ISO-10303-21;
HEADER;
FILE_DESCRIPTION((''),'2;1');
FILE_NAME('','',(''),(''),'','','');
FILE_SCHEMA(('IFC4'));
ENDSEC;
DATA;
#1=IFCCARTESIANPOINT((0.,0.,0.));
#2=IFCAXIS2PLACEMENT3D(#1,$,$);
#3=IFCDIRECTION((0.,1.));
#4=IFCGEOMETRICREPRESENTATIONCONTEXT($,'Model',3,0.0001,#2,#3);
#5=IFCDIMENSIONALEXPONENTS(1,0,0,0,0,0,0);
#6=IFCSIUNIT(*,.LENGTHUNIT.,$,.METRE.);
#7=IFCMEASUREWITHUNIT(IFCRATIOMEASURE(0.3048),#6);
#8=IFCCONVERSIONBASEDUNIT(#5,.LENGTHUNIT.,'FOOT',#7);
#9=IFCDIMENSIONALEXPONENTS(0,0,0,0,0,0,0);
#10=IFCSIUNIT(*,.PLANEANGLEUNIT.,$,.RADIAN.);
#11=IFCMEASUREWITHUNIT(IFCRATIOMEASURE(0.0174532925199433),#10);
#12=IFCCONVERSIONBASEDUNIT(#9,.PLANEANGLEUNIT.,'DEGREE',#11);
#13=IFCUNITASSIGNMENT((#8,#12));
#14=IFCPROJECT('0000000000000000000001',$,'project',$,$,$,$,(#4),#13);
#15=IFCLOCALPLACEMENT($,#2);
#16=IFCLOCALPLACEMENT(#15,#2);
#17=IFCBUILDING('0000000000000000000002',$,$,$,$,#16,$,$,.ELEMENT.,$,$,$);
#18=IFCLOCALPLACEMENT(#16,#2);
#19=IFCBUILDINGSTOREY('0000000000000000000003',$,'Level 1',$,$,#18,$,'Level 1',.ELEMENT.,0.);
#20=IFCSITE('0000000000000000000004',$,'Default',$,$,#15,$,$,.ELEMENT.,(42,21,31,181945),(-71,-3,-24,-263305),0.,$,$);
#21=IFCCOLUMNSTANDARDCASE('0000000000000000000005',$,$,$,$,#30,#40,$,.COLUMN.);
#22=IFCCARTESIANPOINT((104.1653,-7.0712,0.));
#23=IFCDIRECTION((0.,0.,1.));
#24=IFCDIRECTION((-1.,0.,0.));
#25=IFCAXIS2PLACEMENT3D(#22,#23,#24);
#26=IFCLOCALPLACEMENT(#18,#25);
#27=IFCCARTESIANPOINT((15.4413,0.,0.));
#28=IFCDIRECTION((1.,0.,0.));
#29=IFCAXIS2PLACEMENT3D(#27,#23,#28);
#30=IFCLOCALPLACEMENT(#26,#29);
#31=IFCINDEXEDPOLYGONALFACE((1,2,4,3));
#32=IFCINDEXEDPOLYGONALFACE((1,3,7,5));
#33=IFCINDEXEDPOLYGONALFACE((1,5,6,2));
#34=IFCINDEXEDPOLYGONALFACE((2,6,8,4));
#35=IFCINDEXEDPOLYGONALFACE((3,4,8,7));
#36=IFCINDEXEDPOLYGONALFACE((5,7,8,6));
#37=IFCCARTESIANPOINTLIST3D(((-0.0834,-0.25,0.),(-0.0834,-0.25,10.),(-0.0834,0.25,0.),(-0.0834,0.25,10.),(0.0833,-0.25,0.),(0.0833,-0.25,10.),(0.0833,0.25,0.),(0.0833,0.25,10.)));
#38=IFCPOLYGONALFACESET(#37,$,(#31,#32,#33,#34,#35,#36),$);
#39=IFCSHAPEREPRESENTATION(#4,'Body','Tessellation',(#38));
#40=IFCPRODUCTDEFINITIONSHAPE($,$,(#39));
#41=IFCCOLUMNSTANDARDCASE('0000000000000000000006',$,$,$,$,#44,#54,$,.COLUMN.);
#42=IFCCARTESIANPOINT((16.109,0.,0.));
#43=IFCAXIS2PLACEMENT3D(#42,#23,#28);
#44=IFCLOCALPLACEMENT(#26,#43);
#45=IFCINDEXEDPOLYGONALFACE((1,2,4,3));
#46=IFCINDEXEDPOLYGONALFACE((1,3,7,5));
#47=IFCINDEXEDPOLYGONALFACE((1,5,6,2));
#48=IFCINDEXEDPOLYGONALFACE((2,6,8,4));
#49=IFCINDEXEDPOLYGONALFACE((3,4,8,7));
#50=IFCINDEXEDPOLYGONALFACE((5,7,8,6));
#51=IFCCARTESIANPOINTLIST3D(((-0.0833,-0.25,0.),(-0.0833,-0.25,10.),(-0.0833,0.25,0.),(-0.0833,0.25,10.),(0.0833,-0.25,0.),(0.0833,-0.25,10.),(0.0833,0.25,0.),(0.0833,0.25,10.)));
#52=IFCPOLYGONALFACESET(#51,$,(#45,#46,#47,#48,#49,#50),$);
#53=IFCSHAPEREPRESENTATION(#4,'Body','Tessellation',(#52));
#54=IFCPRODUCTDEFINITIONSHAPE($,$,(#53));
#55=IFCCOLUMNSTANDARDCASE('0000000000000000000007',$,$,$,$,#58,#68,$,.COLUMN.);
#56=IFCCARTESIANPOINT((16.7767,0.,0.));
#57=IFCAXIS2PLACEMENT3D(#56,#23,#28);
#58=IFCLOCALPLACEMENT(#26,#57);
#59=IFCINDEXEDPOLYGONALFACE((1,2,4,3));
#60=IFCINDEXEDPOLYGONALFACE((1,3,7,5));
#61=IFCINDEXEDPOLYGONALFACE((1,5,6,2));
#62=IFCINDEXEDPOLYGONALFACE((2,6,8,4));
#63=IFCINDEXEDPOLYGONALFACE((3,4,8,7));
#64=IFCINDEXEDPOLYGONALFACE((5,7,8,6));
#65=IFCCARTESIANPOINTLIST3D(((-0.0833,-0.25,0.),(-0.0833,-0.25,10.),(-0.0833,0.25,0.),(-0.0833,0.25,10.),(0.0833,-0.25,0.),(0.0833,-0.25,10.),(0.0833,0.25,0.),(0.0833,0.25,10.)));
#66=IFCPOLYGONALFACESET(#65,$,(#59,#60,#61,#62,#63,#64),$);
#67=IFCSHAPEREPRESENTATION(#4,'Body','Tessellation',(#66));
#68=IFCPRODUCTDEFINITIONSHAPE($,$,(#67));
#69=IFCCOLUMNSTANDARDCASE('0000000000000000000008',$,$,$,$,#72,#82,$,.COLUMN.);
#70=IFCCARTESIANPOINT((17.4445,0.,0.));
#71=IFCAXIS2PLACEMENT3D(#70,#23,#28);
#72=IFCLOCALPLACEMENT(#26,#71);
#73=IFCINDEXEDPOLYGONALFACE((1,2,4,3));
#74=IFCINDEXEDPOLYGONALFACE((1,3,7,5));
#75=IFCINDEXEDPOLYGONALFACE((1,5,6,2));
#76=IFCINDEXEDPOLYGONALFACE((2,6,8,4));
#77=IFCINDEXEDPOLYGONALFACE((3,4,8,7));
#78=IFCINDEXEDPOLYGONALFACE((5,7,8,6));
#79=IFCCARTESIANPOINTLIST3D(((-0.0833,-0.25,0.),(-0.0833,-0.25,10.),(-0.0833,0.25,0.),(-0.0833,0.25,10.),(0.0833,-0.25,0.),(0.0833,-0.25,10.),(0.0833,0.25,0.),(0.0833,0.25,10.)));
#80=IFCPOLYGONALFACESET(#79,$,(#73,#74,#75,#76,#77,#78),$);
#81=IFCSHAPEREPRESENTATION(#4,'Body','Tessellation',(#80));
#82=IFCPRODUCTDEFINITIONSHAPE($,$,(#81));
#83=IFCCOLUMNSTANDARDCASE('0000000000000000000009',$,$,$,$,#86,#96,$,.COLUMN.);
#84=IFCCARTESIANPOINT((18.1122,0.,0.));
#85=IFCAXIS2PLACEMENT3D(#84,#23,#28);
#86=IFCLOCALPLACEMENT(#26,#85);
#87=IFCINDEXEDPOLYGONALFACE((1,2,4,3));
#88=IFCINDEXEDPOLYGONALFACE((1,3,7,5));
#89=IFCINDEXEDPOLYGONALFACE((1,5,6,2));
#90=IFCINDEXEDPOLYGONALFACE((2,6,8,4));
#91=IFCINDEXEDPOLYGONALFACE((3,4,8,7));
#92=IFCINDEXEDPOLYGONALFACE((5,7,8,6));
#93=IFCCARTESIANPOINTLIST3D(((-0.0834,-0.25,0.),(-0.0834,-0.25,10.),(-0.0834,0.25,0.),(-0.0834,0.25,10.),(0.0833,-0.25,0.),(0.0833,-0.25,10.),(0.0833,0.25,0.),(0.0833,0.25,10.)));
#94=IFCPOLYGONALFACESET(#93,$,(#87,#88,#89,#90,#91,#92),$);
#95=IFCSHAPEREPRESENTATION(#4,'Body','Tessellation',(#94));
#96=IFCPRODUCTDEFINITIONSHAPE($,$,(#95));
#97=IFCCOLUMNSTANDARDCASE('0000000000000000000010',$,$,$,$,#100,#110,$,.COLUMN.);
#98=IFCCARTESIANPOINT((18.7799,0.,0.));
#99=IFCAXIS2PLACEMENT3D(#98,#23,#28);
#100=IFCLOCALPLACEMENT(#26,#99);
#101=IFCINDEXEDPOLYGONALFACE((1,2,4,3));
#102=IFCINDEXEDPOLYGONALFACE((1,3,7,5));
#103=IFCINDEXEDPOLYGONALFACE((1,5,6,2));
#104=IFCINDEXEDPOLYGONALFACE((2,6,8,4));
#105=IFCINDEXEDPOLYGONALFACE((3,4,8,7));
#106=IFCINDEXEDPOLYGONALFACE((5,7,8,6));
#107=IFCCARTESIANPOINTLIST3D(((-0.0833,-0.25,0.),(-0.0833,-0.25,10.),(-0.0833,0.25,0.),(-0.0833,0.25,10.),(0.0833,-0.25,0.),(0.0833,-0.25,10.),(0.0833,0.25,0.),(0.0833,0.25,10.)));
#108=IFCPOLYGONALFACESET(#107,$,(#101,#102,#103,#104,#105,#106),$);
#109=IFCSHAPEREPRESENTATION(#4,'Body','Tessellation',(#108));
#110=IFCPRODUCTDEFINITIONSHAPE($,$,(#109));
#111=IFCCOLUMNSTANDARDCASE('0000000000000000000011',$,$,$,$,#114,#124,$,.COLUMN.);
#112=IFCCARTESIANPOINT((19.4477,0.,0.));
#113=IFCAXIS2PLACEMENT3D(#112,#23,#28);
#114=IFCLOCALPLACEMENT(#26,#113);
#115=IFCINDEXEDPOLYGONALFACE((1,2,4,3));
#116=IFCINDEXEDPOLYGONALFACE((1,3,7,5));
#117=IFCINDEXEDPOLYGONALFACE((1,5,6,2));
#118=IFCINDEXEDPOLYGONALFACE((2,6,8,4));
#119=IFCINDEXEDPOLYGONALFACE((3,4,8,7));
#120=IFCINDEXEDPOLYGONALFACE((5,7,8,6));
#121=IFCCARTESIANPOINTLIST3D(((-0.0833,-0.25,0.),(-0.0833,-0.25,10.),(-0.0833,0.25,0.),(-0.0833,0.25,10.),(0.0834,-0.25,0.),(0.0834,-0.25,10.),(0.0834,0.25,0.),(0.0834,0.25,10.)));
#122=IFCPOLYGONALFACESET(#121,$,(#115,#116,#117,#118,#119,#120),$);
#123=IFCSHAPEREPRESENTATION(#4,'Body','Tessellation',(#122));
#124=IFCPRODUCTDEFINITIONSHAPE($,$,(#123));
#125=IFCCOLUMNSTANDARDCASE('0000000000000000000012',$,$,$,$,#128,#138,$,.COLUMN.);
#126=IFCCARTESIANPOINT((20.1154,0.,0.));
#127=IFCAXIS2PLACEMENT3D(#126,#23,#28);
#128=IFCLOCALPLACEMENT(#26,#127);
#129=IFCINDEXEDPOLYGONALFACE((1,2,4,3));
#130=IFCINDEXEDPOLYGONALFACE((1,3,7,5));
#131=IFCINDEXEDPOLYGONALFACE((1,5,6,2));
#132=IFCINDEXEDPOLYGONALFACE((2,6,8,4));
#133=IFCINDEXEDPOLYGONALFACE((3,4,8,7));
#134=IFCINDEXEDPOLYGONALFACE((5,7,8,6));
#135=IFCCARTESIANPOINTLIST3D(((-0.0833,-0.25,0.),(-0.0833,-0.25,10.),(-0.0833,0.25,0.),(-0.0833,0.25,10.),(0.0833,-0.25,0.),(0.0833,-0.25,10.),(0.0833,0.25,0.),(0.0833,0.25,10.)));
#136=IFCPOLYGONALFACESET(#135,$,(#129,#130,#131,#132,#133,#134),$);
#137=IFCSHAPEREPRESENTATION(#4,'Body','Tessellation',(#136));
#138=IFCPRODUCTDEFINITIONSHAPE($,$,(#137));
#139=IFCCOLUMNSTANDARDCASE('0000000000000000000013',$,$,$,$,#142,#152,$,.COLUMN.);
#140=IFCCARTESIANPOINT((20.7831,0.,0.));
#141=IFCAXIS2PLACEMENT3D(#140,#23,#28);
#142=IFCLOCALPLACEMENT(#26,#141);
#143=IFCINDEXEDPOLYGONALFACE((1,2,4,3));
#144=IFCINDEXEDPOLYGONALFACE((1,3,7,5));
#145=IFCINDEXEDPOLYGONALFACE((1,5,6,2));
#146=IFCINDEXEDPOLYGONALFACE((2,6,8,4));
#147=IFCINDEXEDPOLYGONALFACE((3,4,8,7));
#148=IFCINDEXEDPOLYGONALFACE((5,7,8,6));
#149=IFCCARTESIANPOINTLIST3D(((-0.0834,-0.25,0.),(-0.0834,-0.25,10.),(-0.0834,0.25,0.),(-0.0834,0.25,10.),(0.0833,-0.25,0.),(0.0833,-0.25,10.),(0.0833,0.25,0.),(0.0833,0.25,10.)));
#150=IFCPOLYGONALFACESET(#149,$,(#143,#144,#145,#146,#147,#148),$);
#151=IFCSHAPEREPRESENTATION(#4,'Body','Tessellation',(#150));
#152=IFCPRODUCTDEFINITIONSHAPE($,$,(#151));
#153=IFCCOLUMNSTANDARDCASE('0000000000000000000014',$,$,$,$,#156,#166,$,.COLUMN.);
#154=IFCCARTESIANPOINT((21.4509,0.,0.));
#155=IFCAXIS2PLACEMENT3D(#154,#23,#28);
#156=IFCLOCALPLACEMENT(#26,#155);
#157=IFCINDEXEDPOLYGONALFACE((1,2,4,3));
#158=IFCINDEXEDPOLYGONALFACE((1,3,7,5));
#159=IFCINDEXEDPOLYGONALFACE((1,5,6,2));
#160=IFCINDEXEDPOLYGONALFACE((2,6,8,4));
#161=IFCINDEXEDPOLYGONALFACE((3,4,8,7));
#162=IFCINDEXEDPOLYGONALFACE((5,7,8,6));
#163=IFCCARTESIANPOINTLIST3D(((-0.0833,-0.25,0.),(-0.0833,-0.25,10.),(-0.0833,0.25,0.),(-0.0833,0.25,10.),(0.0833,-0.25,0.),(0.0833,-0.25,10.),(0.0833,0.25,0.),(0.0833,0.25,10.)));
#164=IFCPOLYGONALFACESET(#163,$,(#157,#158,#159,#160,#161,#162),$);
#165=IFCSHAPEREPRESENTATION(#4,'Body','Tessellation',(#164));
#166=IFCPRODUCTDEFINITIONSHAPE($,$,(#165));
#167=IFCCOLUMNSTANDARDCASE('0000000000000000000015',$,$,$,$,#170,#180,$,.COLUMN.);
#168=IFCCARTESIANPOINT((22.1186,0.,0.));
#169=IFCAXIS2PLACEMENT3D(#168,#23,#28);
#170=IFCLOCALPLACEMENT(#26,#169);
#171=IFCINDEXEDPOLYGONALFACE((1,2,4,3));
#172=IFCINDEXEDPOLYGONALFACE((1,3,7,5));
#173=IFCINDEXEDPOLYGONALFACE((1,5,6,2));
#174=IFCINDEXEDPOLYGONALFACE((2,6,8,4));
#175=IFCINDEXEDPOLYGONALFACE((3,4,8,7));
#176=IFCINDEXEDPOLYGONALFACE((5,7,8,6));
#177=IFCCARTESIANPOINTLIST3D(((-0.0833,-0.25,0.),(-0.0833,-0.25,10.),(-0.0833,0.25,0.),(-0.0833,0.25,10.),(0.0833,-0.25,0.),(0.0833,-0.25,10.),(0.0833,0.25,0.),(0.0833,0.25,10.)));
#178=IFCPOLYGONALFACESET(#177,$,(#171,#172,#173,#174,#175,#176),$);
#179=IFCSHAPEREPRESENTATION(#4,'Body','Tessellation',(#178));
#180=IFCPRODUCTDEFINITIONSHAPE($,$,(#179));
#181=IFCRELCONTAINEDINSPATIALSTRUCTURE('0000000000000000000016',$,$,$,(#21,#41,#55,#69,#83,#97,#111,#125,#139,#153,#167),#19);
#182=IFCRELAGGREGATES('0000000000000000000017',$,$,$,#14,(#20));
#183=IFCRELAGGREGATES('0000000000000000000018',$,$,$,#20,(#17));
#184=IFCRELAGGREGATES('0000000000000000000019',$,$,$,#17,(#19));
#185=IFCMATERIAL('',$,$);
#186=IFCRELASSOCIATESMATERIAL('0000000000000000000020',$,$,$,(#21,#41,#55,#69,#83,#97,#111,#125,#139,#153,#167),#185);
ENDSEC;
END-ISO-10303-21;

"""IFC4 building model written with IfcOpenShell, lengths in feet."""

from ifc_helpers import new_model, entity, si_unit, converted_unit, direction, frame, origin, place, context, project, spatial, rectangle, extrude, material, element, save


model = new_model("IFC4")

# Units and contexts
model_context = context("Model", 3, precision=0.0001, world=origin(), true_north=direction((0.0, 1.0)))
ifc_project = project(units=[converted_unit("LENGTHUNIT", "FOOT", entity("IfcRatioMeasure", 0.3048), si_unit("LENGTHUNIT", "METRE"), dimensions=[1, 0, 0, 0, 0, 0, 0]), converted_unit("PLANEANGLEUNIT", "DEGREE", entity("IfcRatioMeasure", 0.0174532925199433), si_unit("PLANEANGLEUNIT", "RADIAN"), dimensions=[0, 0, 0, 0, 0, 0, 0])], contexts=[model_context])

# Site, building, storey
site_placement = place(None, origin())
site = spatial("IfcSite", under=ifc_project, at=site_placement, Name="Default", CompositionType="ELEMENT", RefLatitude=(42, 21, 31, 181945), RefLongitude=(-71, -3, -24, -263305), RefElevation=0.0)
building_placement = place(site_placement, origin())
building = spatial("IfcBuilding", under=site, at=building_placement, CompositionType="ELEMENT")
storey_placement = place(building_placement, origin())
storey = spatial("IfcBuildingStorey", under=building, at=storey_placement, Name="Level 1", LongName="Level 1", CompositionType="ELEMENT", Elevation=0.0)

# Columns
ifc_material = material(Name="")
placement = place(storey_placement, frame((104.1653, -7.0712, 0.0), z_axis=(0.0, 0.0, 1.0), x_axis=(-1.0, 0.0, 0.0)))
for number, where, z_axis, x_axis in (
    (1, (15.4413, 0.0, 0.0), (0.0, 0.0, 1.0), (1.0, 0.0, 0.0)),
    (2, (16.109, 0.0, 0.0), (0.0, 0.0, 1.0), (1.0, 0.0, 0.0)),
    (3, (16.7767, 0.0, 0.0), (0.0, 0.0, 1.0), (1.0, 0.0, 0.0)),
    (4, (17.4445, 0.0, 0.0), (0.0, 0.0, 1.0), (1.0, 0.0, 0.0)),
    (5, (18.1122, 0.0, 0.0), (0.0, 0.0, 1.0), (1.0, 0.0, 0.0)),
    (6, (18.7799, 0.0, 0.0), (0.0, 0.0, 1.0), (1.0, 0.0, 0.0)),
    (7, (19.4477, 0.0, 0.0), (0.0, 0.0, 1.0), (1.0, 0.0, 0.0)),
    (8, (20.1154, 0.0, 0.0), (0.0, 0.0, 1.0), (1.0, 0.0, 0.0)),
    (9, (20.7831, 0.0, 0.0), (0.0, 0.0, 1.0), (1.0, 0.0, 0.0)),
    (10, (21.4509, 0.0, 0.0), (0.0, 0.0, 1.0), (1.0, 0.0, 0.0)),
    (11, (22.1186, 0.0, 0.0), (0.0, 0.0, 1.0), (1.0, 0.0, 0.0)),
):
    element("IfcColumnStandardCase", number, at=place(placement, frame(where, z_axis=z_axis, x_axis=x_axis)), inside=storey, material=ifc_material, PredefinedType="COLUMN", context=model_context, shape_type="SweptSolid", body=[
        extrude(rectangle(XDim=0.1667, YDim=0.5), origin(), (0.0, 0.0, 1.0), 10.0),
    ])

save(model, "model.ifc")
